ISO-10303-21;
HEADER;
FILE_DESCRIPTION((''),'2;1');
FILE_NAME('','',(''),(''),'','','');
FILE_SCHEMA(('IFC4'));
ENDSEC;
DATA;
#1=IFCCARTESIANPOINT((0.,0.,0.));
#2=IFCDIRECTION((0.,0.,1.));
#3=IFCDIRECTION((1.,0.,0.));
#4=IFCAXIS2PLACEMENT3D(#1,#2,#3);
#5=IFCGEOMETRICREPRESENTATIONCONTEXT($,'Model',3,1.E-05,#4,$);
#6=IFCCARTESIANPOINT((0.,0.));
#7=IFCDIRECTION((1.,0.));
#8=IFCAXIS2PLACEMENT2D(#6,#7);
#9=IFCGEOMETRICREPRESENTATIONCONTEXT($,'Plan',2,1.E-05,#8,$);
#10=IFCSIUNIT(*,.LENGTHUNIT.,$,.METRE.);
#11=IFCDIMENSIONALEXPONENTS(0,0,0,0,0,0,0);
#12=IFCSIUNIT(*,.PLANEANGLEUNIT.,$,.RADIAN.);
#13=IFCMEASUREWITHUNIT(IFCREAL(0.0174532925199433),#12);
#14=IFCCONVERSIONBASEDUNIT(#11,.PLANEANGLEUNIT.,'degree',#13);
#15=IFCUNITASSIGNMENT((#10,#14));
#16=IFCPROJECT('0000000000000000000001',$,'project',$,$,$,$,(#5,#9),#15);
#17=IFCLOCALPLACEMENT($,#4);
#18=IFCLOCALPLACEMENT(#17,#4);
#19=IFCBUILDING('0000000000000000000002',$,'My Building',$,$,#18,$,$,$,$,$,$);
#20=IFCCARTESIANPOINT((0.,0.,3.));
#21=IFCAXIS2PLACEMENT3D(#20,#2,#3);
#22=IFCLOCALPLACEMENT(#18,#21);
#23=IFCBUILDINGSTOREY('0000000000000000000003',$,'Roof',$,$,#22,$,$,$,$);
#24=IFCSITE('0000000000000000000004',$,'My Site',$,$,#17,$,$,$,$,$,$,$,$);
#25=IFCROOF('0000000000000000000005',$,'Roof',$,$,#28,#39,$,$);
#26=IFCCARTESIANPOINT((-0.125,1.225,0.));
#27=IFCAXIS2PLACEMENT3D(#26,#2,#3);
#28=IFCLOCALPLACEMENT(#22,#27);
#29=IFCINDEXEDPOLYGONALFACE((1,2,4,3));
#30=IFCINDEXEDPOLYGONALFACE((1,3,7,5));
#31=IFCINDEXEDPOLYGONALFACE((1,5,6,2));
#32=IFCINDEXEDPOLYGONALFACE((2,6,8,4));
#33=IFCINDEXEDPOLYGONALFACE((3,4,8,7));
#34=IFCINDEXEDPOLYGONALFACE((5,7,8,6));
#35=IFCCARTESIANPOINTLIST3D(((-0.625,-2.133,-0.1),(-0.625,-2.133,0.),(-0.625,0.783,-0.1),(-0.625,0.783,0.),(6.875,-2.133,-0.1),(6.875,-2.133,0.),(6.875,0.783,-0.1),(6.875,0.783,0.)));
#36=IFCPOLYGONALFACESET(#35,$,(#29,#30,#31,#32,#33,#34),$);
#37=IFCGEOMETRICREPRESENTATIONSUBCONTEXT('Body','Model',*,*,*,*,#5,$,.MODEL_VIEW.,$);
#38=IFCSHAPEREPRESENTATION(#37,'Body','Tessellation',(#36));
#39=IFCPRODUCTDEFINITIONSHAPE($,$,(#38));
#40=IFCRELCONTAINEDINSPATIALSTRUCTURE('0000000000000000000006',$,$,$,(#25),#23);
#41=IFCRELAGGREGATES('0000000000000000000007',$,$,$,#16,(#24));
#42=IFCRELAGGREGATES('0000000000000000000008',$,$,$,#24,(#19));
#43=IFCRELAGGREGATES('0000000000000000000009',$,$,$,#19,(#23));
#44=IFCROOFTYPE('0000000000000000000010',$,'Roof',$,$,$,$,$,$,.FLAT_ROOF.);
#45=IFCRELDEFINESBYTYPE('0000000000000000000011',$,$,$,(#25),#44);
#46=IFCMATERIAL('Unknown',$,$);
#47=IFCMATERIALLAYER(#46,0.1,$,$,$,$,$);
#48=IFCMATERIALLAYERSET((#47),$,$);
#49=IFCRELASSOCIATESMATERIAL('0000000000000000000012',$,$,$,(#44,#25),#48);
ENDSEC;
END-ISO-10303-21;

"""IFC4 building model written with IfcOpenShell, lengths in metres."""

from ifc_helpers import new_model, entity, si_unit, converted_unit, frame, origin_with_axes, origin_2d_with_axis, place, context, subcontext, project, spatial, indexed_curve, outline, extrude, material, layer, layer_set, layer_usage, type_object, element, save


model = new_model("IFC4")

# Units and contexts
model_context = context("Model", 3, precision=1e-05, world=origin_with_axes())
plan_context = context("Plan", 2, precision=1e-05, world=origin_2d_with_axis())
body_context = subcontext(model_context, "Body", "Model", "MODEL_VIEW")
ifc_project = project(units=[si_unit("LENGTHUNIT", "METRE"), converted_unit("PLANEANGLEUNIT", "degree", entity("IfcReal", 0.0174532925199433), si_unit("PLANEANGLEUNIT", "RADIAN"), dimensions=[0, 0, 0, 0, 0, 0, 0])], contexts=[model_context, plan_context])

# Site, building, storey
site_placement = place(None, origin_with_axes())
site = spatial("IfcSite", under=ifc_project, at=site_placement, Name="My Site")
building_placement = place(site_placement, origin_with_axes())
building = spatial("IfcBuilding", under=site, at=building_placement, Name="My Building")
storey_placement = place(building_placement, frame((0.0, 0.0, 3.0), z_axis=(0.0, 0.0, 1.0), x_axis=(1.0, 0.0, 0.0)))
storey = spatial("IfcBuildingStorey", under=building, at=storey_placement, Name="Roof")

# Roof
ifc_material = material(Name="Unknown")
ifc_layer = layer(ifc_material, 0.1)
ifc_layer_set = layer_set([ifc_layer])
ifc_layer_usage = layer_usage(ifc_layer_set, "AXIS3", "POSITIVE", -0.1)
roof_type = type_object("IfcRoofType", Name="Roof", PredefinedType="FLAT_ROOF", material=ifc_layer_set)
roof_placement = place(storey_placement, frame((-0.125, 1.225, 0.0), z_axis=(0.0, 0.0, 1.0), x_axis=(1.0, 0.0, 0.0)))
element("IfcRoof", 1, at=roof_placement, inside=storey, type_object=roof_type, material=ifc_layer_usage, Name="Roof", context=body_context, shape_type="SweptSolid", body=[
    extrude(outline(indexed_curve([(-0.625, -2.133), (6.875, -2.133), (6.875, 0.783), (-0.625, 0.783), (-0.625, -2.133)])), frame((0.0, 0.0, -0.1), z_axis=(0.0, 0.0, 1.0), x_axis=(1.0, 0.0, 0.0)), (0.0, 0.0, 1.0), 0.1),
])

save(model, "model.ifc")
